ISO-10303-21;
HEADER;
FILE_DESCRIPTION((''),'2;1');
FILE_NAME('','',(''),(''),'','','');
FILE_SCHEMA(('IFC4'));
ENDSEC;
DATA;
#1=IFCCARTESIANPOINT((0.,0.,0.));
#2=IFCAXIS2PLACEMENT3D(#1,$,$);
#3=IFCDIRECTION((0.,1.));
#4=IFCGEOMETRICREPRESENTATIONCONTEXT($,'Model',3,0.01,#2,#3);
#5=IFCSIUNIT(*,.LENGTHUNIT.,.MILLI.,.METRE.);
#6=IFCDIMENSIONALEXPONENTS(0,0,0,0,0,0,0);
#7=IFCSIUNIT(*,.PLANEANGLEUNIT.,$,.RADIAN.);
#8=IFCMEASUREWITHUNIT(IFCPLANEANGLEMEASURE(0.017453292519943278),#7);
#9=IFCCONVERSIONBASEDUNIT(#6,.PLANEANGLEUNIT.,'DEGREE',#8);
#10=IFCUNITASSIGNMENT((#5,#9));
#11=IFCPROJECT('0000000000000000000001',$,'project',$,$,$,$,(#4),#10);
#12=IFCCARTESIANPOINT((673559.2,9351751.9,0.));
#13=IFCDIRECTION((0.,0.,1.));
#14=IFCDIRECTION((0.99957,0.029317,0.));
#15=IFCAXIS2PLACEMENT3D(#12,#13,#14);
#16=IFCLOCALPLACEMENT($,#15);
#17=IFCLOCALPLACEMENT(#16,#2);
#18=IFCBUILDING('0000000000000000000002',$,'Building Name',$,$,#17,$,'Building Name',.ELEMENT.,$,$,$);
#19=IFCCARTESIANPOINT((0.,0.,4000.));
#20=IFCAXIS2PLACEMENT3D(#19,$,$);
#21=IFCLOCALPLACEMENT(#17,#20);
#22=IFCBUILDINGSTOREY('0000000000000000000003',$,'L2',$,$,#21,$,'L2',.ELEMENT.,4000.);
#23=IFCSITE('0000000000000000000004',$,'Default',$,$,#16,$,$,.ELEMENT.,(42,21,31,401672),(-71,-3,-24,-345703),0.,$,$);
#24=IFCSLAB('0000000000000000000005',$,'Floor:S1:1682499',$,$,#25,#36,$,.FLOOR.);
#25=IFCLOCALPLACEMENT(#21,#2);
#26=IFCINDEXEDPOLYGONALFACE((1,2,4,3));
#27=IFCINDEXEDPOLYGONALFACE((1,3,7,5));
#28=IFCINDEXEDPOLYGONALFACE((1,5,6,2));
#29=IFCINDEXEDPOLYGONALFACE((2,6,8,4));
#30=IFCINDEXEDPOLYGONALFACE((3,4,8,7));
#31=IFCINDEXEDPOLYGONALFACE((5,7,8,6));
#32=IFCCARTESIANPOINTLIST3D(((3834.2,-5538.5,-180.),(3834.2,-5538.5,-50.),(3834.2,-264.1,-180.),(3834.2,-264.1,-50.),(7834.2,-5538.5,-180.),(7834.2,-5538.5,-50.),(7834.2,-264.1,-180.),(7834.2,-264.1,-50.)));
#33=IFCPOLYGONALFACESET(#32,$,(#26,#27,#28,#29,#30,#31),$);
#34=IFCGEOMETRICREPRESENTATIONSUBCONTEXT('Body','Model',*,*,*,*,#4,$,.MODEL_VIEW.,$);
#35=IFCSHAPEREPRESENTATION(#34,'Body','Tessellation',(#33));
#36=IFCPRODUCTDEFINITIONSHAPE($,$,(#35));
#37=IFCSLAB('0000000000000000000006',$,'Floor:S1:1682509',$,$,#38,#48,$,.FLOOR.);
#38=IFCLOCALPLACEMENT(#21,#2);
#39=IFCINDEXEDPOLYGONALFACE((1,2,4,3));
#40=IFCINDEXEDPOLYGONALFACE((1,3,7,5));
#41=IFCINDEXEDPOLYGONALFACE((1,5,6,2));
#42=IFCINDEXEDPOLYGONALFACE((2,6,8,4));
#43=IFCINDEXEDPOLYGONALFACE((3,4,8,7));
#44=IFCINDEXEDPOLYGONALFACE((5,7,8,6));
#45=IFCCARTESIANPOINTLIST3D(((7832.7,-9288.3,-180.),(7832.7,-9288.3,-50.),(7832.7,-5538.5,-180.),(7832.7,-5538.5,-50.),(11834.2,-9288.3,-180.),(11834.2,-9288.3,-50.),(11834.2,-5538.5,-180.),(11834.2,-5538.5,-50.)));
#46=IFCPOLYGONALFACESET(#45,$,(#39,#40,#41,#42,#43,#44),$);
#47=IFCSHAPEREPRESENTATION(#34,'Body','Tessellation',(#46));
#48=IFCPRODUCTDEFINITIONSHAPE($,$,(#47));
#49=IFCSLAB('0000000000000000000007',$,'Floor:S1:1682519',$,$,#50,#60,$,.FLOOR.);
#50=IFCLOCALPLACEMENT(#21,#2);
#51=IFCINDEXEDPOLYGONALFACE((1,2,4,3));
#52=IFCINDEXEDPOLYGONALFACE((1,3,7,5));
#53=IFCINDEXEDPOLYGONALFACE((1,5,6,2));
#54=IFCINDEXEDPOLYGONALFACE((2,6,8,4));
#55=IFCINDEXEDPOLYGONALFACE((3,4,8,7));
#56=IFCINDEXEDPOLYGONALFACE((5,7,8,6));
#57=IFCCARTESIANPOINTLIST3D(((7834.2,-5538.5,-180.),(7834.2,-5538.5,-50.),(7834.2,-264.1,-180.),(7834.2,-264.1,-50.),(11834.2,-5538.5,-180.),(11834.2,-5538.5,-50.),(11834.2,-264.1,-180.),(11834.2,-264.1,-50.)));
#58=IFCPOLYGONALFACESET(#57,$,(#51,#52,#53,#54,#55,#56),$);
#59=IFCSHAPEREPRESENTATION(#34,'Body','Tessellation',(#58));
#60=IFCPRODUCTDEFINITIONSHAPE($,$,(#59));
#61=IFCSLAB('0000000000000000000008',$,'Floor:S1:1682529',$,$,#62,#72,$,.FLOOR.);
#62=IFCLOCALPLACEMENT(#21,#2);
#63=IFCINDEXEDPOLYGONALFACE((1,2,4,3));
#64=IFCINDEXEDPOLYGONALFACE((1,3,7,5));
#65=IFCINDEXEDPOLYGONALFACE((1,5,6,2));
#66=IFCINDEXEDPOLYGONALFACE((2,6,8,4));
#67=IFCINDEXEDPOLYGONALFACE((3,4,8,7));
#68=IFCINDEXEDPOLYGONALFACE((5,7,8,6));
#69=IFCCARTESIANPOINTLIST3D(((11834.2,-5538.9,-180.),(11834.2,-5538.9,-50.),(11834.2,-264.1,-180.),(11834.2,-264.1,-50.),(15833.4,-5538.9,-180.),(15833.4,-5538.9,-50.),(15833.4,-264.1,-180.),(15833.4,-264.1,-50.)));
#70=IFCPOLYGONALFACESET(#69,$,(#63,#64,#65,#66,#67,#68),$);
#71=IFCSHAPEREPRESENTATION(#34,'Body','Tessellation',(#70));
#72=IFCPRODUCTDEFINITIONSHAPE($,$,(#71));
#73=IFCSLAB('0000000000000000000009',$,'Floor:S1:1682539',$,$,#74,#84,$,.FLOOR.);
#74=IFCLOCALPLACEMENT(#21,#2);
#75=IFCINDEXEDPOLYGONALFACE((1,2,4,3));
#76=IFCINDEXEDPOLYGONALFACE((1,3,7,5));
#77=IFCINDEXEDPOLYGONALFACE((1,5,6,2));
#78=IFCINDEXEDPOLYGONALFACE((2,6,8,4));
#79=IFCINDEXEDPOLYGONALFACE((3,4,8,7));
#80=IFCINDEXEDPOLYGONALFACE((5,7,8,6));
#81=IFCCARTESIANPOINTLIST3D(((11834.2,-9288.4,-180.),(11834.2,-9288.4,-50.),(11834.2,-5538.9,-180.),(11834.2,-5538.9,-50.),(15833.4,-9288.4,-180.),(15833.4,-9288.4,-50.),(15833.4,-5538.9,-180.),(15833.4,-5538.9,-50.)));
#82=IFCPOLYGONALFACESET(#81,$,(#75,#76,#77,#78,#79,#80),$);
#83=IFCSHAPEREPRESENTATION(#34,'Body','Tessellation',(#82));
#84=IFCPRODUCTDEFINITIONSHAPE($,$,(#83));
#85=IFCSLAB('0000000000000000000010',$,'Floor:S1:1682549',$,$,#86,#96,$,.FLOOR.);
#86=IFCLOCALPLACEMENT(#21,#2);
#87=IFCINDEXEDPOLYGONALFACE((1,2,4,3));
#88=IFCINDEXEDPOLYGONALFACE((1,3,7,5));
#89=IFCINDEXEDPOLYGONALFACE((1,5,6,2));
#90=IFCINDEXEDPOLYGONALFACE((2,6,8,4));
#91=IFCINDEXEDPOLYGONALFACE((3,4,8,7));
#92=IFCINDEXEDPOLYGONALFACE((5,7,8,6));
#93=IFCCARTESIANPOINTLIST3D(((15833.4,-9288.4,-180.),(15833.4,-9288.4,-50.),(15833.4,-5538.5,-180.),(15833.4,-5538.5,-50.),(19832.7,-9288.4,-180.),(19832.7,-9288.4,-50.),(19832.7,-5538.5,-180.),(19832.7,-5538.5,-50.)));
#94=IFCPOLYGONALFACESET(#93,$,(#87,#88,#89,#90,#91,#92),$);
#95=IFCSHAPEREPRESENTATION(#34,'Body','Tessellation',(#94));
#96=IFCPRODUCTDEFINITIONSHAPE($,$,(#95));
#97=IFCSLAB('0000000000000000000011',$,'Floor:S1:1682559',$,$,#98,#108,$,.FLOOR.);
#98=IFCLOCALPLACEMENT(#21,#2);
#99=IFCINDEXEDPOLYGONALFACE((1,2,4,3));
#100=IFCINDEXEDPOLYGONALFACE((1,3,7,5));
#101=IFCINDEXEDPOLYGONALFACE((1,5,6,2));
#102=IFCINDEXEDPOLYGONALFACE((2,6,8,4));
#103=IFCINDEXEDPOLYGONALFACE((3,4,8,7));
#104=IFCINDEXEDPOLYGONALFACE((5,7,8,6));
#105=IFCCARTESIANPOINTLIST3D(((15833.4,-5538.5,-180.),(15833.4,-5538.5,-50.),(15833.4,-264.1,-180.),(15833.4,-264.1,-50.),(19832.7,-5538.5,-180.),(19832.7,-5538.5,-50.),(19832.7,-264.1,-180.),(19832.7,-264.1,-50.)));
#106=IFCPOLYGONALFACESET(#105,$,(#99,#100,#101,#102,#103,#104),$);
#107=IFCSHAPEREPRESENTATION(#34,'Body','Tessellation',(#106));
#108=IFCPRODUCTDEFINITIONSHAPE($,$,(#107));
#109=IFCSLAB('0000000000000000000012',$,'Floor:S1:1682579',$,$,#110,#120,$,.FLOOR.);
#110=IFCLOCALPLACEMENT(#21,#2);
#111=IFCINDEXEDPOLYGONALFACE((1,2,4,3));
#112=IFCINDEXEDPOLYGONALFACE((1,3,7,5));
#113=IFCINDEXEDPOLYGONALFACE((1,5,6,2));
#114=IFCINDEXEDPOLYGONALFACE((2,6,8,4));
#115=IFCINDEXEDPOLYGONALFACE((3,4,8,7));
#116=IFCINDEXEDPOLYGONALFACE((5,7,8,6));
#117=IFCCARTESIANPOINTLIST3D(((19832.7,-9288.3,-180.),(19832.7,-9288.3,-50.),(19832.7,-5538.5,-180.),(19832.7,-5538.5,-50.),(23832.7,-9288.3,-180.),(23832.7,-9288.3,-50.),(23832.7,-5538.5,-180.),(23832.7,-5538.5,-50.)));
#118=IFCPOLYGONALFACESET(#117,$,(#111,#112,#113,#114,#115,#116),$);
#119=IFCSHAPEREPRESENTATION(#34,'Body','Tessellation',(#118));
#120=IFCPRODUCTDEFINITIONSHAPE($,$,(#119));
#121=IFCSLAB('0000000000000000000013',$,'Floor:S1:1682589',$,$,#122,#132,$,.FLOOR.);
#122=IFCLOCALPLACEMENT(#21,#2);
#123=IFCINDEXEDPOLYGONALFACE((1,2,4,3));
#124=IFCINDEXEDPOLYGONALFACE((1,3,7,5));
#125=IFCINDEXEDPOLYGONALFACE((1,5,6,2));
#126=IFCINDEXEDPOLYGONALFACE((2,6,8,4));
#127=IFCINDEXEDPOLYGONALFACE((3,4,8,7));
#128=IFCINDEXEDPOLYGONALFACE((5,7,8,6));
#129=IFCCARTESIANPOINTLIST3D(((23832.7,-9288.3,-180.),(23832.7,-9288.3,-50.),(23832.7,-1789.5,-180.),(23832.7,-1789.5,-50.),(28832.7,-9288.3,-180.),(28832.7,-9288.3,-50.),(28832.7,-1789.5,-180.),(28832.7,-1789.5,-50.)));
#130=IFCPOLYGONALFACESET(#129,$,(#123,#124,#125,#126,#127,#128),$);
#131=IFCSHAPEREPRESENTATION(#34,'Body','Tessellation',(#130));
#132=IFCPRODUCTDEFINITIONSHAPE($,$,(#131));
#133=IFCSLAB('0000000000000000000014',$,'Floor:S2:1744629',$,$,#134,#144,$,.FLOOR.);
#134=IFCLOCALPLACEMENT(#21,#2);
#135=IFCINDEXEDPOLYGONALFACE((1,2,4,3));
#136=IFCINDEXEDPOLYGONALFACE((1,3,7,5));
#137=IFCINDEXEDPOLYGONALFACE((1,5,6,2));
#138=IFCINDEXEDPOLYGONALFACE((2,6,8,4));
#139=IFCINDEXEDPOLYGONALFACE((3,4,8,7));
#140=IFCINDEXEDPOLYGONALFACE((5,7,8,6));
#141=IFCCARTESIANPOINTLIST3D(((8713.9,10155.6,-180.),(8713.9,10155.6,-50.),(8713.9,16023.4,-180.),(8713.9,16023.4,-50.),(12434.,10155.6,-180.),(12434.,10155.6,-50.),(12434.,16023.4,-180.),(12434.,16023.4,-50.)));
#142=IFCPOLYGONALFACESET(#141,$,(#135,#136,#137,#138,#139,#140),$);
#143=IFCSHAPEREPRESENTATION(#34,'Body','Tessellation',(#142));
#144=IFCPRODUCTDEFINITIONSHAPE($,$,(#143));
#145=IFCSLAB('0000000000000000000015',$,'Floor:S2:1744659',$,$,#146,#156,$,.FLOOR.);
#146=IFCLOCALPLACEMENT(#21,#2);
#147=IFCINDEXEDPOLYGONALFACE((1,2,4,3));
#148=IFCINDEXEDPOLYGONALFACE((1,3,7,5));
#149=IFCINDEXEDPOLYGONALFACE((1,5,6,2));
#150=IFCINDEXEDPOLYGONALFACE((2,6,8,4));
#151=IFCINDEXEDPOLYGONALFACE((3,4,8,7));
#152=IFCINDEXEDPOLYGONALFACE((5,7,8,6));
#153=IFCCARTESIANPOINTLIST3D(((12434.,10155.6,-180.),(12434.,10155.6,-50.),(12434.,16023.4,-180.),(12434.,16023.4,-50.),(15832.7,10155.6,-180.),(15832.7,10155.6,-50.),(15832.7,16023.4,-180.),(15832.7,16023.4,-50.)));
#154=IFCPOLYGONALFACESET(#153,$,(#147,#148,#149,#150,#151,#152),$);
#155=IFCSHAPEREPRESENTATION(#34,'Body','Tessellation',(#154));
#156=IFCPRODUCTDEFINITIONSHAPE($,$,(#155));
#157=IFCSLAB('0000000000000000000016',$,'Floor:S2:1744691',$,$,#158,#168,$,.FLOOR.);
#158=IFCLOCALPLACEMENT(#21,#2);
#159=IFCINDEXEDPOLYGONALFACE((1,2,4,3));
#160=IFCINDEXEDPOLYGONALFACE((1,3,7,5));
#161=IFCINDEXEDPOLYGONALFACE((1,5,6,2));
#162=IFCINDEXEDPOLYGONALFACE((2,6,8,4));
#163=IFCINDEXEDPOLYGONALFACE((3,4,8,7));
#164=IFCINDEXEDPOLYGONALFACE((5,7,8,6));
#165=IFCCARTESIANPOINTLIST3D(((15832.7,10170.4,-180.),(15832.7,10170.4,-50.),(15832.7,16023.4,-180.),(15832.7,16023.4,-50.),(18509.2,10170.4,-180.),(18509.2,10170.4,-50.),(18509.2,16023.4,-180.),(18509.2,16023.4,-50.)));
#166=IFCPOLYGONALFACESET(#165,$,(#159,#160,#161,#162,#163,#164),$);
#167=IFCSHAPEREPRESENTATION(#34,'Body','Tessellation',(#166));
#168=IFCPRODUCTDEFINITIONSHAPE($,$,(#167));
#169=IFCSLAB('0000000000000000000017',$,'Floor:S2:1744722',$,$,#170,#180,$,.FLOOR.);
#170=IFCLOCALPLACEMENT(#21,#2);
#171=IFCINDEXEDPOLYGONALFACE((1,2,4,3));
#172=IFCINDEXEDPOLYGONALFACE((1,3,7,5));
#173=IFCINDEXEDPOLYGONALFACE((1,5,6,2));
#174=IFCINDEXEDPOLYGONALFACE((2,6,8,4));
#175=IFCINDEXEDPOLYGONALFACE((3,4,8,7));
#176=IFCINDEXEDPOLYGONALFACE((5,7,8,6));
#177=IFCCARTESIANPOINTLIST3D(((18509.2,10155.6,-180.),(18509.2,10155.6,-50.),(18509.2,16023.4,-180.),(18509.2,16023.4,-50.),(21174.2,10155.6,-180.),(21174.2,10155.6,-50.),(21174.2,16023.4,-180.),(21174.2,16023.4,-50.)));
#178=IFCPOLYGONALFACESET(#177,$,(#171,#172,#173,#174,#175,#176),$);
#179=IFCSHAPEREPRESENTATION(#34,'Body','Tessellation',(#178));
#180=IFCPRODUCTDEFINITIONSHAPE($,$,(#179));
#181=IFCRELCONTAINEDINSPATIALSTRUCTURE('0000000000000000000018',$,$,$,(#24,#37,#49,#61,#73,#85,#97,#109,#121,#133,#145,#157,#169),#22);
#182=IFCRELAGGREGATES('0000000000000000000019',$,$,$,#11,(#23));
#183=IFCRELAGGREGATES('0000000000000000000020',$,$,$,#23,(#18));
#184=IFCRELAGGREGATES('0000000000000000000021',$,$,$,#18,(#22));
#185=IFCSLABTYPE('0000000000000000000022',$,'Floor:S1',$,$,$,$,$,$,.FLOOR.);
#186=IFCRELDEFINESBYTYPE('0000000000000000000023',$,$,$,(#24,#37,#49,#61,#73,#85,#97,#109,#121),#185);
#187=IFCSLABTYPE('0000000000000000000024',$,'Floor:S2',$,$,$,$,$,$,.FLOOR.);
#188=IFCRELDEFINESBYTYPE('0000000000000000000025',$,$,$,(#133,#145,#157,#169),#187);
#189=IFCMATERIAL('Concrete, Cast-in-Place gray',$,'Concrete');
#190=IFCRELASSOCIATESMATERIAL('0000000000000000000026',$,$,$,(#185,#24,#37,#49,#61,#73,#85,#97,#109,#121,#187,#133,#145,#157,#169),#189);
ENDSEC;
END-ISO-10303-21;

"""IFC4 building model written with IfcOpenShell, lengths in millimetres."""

from ifc_helpers import new_model, entity, si_unit, converted_unit, direction, frame, origin, place, context, subcontext, project, spatial, indexed_curve, outline, extrude, material, type_object, element, save


model = new_model("IFC4")

# Units and contexts
model_context = context("Model", 3, precision=0.01, world=origin(), true_north=direction((0.0, 1.0)))
body_context = subcontext(model_context, "Body", "Model", "MODEL_VIEW")
ifc_project = project(units=[si_unit("LENGTHUNIT", "METRE", prefix="MILLI"), converted_unit("PLANEANGLEUNIT", "DEGREE", entity("IfcPlaneAngleMeasure", 0.017453292519943278), si_unit("PLANEANGLEUNIT", "RADIAN"), dimensions=[0, 0, 0, 0, 0, 0, 0])], contexts=[model_context])

# Site, building, storey
site_placement = place(None, frame((673559.2, 9351751.9, 0.0), z_axis=(0.0, 0.0, 1.0), x_axis=(0.99957, 0.029317, 0.0)))
site = spatial("IfcSite", under=ifc_project, at=site_placement, Name="Default", CompositionType="ELEMENT", RefLatitude=(42, 21, 31, 401672), RefLongitude=(-71, -3, -24, -345703), RefElevation=0.0)
building_placement = place(site_placement, origin())
building = spatial("IfcBuilding", under=site, at=building_placement, Name="Building Name", LongName="Building Name", CompositionType="ELEMENT")
storey_placement = place(building_placement, frame((0.0, 0.0, 4000.0)))
storey = spatial("IfcBuildingStorey", under=building, at=storey_placement, Name="L2", LongName="L2", CompositionType="ELEMENT", Elevation=4000.0)

# Slabs
ifc_material_1 = material(Name="Concrete, Cast-in-Place gray", Category="Concrete")
slab_type_1 = type_object("IfcSlabType", Name="Floor:S1", PredefinedType="FLOOR", material=ifc_material_1)
slab_1_placement = place(storey_placement, origin())
element("IfcSlab", 1, at=slab_1_placement, inside=storey, type_object=slab_type_1, material=ifc_material_1, Name="Floor:S1:1682499", PredefinedType="FLOOR", context=body_context, shape_type="SweptSolid", body=[
    extrude(outline(indexed_curve([(-2637.2, -2000.0), (2637.2, -2000.0), (2637.2, 2000.0), (-2637.2, 2000.0), (-2637.2, -2000.0)], self_intersect=False)), frame((5834.2, -2901.3, -50.0), z_axis=(0.0, 0.0, -1.0), x_axis=(0.0, 1.0, 0.0)), (0.0, 0.0, 1.0), 130.0),
])
slab_2_placement = place(storey_placement, origin())
element("IfcSlab", 2, at=slab_2_placement, inside=storey, type_object=slab_type_1, material=ifc_material_1, Name="Floor:S1:1682509", PredefinedType="FLOOR", context=body_context, shape_type="SweptSolid", body=[
    extrude(outline(indexed_curve([(-1874.9, -2000.7), (1874.9, -2000.7), (1874.9, 2000.7), (-1874.9, 2000.7), (-1874.9, -2000.7)], self_intersect=False)), frame((9833.4, -7413.4, -50.0), z_axis=(0.0, 0.0, -1.0), x_axis=(0.0, 1.0, 0.0)), (0.0, 0.0, 1.0), 130.0),
])
slab_3_placement = place(storey_placement, origin())
element("IfcSlab", 3, at=slab_3_placement, inside=storey, type_object=slab_type_1, material=ifc_material_1, Name="Floor:S1:1682519", PredefinedType="FLOOR", context=body_context, shape_type="SweptSolid", body=[
    extrude(outline(indexed_curve([(-2637.2, -2000.0), (2637.2, -2000.0), (2637.2, 2000.0), (-2637.2, 2000.0), (-2637.2, -2000.0)], self_intersect=False)), frame((9834.2, -2901.3, -50.0), z_axis=(0.0, 0.0, -1.0), x_axis=(0.0, 1.0, 0.0)), (0.0, 0.0, 1.0), 130.0),
])
slab_4_placement = place(storey_placement, origin())
element("IfcSlab", 4, at=slab_4_placement, inside=storey, type_object=slab_type_1, material=ifc_material_1, Name="Floor:S1:1682529", PredefinedType="FLOOR", context=body_context, shape_type="SweptSolid", body=[
    extrude(outline(indexed_curve([(-2637.4, -1999.6), (2637.4, -1999.6), (2637.4, 1999.6), (-2637.4, 1999.6), (-2637.4, -1999.6)], self_intersect=False)), frame((13833.8, -2901.5, -50.0), z_axis=(0.0, 0.0, -1.0), x_axis=(0.0, 1.0, 0.0)), (0.0, 0.0, 1.0), 130.0),
])
slab_5_placement = place(storey_placement, origin())
element("IfcSlab", 5, at=slab_5_placement, inside=storey, type_object=slab_type_1, material=ifc_material_1, Name="Floor:S1:1682539", PredefinedType="FLOOR", context=body_context, shape_type="SweptSolid", body=[
    extrude(outline(indexed_curve([(-1874.7, -1999.6), (1874.7, -1999.6), (1874.7, 1999.6), (-1874.7, 1999.6), (-1874.7, -1999.6)], self_intersect=False)), frame((13833.8, -7413.6, -50.0), z_axis=(0.0, 0.0, -1.0), x_axis=(0.0, 1.0, 0.0)), (0.0, 0.0, 1.0), 130.0),
])
slab_6_placement = place(storey_placement, origin())
element("IfcSlab", 6, at=slab_6_placement, inside=storey, type_object=slab_type_1, material=ifc_material_1, Name="Floor:S1:1682549", PredefinedType="FLOOR", context=body_context, shape_type="SweptSolid", body=[
    extrude(outline(indexed_curve([(-1874.9, -1999.6), (1874.9, -1999.6), (1874.9, 1999.6), (-1874.9, 1999.6), (-1874.9, -1999.6)], self_intersect=False)), frame((17833.0, -7413.5, -50.0), z_axis=(0.0, 0.0, -1.0), x_axis=(0.0, 1.0, 0.0)), (0.0, 0.0, 1.0), 130.0),
])
slab_7_placement = place(storey_placement, origin())
element("IfcSlab", 7, at=slab_7_placement, inside=storey, type_object=slab_type_1, material=ifc_material_1, Name="Floor:S1:1682559", PredefinedType="FLOOR", context=body_context, shape_type="SweptSolid", body=[
    extrude(outline(indexed_curve([(-2637.2, -1999.6), (2637.2, -1999.6), (2637.2, 1999.6), (-2637.2, 1999.6), (-2637.2, -1999.6)], self_intersect=False)), frame((17833.0, -2901.3, -50.0), z_axis=(0.0, 0.0, -1.0), x_axis=(0.0, 1.0, 0.0)), (0.0, 0.0, 1.0), 130.0),
])
slab_8_placement = place(storey_placement, origin())
element("IfcSlab", 8, at=slab_8_placement, inside=storey, type_object=slab_type_1, material=ifc_material_1, Name="Floor:S1:1682579", PredefinedType="FLOOR", context=body_context, shape_type="SweptSolid", body=[
    extrude(outline(indexed_curve([(-1874.9, -2000.0), (1874.9, -2000.0), (1874.9, 2000.0), (-1874.9, 2000.0), (-1874.9, -2000.0)], self_intersect=False)), frame((21832.7, -7413.4, -50.0), z_axis=(0.0, 0.0, -1.0), x_axis=(0.0, 1.0, 0.0)), (0.0, 0.0, 1.0), 130.0),
])
slab_9_placement = place(storey_placement, origin())
element("IfcSlab", 9, at=slab_9_placement, inside=storey, type_object=slab_type_1, material=ifc_material_1, Name="Floor:S1:1682589", PredefinedType="FLOOR", context=body_context, shape_type="SweptSolid", body=[
    extrude(outline(indexed_curve([(-3749.4, -2500.0), (3749.4, -2500.0), (3749.4, 2500.0), (-3749.4, 2500.0), (-3749.4, -2500.0)], self_intersect=False)), frame((26332.7, -5538.9, -50.0), z_axis=(0.0, 0.0, -1.0), x_axis=(0.0, 1.0, 0.0)), (0.0, 0.0, 1.0), 130.0),
])

# Slabs
slab_type_2 = type_object("IfcSlabType", Name="Floor:S2", PredefinedType="FLOOR", material=ifc_material_1)
slab_10_placement = place(storey_placement, origin())
element("IfcSlab", 10, at=slab_10_placement, inside=storey, type_object=slab_type_2, material=ifc_material_1, Name="Floor:S2:1744629", PredefinedType="FLOOR", context=body_context, shape_type="SweptSolid", body=[
    extrude(outline(indexed_curve([(-2933.9, -1860.1), (2933.9, -1860.1), (2933.9, 1860.1), (-2933.9, 1860.1), (-2933.9, -1860.1)], self_intersect=False)), frame((10574.0, 13089.5, -50.0), z_axis=(0.0, 0.0, -1.0), x_axis=(0.0, 1.0, 0.0)), (0.0, 0.0, 1.0), 130.0),
])
slab_11_placement = place(storey_placement, origin())
element("IfcSlab", 11, at=slab_11_placement, inside=storey, type_object=slab_type_2, material=ifc_material_1, Name="Floor:S2:1744659", PredefinedType="FLOOR", context=body_context, shape_type="SweptSolid", body=[
    extrude(outline(indexed_curve([(-2933.9, -1699.3), (2933.9, -1699.3), (2933.9, 1699.3), (-2933.9, 1699.3), (-2933.9, -1699.3)], self_intersect=False)), frame((14133.4, 13089.5, -50.0), z_axis=(0.0, 0.0, -1.0), x_axis=(0.0, 1.0, 0.0)), (0.0, 0.0, 1.0), 130.0),
])
slab_12_placement = place(storey_placement, origin())
element("IfcSlab", 12, at=slab_12_placement, inside=storey, type_object=slab_type_2, material=ifc_material_1, Name="Floor:S2:1744691", PredefinedType="FLOOR", context=body_context, shape_type="SweptSolid", body=[
    extrude(outline(indexed_curve([(-2926.5, -1338.3), (2926.5, -1338.3), (2926.5, 1338.3), (-2926.5, 1338.3), (-2926.5, -1338.3)], self_intersect=False)), frame((17170.9, 13096.9, -50.0), z_axis=(0.0, 0.0, -1.0), x_axis=(0.0, 1.0, 0.0)), (0.0, 0.0, 1.0), 130.0),
])
slab_13_placement = place(storey_placement, origin())
element("IfcSlab", 13, at=slab_13_placement, inside=storey, type_object=slab_type_2, material=ifc_material_1, Name="Floor:S2:1744722", PredefinedType="FLOOR", context=body_context, shape_type="SweptSolid", body=[
    extrude(outline(indexed_curve([(-2933.9, -1332.5), (2933.9, -1332.5), (2933.9, 1332.5), (-2933.9, 1332.5), (-2933.9, -1332.5)], self_intersect=False)), frame((19841.7, 13089.5, -50.0), z_axis=(0.0, 0.0, -1.0), x_axis=(0.0, 1.0, 0.0)), (0.0, 0.0, 1.0), 130.0),
])

save(model, "model.ifc")
